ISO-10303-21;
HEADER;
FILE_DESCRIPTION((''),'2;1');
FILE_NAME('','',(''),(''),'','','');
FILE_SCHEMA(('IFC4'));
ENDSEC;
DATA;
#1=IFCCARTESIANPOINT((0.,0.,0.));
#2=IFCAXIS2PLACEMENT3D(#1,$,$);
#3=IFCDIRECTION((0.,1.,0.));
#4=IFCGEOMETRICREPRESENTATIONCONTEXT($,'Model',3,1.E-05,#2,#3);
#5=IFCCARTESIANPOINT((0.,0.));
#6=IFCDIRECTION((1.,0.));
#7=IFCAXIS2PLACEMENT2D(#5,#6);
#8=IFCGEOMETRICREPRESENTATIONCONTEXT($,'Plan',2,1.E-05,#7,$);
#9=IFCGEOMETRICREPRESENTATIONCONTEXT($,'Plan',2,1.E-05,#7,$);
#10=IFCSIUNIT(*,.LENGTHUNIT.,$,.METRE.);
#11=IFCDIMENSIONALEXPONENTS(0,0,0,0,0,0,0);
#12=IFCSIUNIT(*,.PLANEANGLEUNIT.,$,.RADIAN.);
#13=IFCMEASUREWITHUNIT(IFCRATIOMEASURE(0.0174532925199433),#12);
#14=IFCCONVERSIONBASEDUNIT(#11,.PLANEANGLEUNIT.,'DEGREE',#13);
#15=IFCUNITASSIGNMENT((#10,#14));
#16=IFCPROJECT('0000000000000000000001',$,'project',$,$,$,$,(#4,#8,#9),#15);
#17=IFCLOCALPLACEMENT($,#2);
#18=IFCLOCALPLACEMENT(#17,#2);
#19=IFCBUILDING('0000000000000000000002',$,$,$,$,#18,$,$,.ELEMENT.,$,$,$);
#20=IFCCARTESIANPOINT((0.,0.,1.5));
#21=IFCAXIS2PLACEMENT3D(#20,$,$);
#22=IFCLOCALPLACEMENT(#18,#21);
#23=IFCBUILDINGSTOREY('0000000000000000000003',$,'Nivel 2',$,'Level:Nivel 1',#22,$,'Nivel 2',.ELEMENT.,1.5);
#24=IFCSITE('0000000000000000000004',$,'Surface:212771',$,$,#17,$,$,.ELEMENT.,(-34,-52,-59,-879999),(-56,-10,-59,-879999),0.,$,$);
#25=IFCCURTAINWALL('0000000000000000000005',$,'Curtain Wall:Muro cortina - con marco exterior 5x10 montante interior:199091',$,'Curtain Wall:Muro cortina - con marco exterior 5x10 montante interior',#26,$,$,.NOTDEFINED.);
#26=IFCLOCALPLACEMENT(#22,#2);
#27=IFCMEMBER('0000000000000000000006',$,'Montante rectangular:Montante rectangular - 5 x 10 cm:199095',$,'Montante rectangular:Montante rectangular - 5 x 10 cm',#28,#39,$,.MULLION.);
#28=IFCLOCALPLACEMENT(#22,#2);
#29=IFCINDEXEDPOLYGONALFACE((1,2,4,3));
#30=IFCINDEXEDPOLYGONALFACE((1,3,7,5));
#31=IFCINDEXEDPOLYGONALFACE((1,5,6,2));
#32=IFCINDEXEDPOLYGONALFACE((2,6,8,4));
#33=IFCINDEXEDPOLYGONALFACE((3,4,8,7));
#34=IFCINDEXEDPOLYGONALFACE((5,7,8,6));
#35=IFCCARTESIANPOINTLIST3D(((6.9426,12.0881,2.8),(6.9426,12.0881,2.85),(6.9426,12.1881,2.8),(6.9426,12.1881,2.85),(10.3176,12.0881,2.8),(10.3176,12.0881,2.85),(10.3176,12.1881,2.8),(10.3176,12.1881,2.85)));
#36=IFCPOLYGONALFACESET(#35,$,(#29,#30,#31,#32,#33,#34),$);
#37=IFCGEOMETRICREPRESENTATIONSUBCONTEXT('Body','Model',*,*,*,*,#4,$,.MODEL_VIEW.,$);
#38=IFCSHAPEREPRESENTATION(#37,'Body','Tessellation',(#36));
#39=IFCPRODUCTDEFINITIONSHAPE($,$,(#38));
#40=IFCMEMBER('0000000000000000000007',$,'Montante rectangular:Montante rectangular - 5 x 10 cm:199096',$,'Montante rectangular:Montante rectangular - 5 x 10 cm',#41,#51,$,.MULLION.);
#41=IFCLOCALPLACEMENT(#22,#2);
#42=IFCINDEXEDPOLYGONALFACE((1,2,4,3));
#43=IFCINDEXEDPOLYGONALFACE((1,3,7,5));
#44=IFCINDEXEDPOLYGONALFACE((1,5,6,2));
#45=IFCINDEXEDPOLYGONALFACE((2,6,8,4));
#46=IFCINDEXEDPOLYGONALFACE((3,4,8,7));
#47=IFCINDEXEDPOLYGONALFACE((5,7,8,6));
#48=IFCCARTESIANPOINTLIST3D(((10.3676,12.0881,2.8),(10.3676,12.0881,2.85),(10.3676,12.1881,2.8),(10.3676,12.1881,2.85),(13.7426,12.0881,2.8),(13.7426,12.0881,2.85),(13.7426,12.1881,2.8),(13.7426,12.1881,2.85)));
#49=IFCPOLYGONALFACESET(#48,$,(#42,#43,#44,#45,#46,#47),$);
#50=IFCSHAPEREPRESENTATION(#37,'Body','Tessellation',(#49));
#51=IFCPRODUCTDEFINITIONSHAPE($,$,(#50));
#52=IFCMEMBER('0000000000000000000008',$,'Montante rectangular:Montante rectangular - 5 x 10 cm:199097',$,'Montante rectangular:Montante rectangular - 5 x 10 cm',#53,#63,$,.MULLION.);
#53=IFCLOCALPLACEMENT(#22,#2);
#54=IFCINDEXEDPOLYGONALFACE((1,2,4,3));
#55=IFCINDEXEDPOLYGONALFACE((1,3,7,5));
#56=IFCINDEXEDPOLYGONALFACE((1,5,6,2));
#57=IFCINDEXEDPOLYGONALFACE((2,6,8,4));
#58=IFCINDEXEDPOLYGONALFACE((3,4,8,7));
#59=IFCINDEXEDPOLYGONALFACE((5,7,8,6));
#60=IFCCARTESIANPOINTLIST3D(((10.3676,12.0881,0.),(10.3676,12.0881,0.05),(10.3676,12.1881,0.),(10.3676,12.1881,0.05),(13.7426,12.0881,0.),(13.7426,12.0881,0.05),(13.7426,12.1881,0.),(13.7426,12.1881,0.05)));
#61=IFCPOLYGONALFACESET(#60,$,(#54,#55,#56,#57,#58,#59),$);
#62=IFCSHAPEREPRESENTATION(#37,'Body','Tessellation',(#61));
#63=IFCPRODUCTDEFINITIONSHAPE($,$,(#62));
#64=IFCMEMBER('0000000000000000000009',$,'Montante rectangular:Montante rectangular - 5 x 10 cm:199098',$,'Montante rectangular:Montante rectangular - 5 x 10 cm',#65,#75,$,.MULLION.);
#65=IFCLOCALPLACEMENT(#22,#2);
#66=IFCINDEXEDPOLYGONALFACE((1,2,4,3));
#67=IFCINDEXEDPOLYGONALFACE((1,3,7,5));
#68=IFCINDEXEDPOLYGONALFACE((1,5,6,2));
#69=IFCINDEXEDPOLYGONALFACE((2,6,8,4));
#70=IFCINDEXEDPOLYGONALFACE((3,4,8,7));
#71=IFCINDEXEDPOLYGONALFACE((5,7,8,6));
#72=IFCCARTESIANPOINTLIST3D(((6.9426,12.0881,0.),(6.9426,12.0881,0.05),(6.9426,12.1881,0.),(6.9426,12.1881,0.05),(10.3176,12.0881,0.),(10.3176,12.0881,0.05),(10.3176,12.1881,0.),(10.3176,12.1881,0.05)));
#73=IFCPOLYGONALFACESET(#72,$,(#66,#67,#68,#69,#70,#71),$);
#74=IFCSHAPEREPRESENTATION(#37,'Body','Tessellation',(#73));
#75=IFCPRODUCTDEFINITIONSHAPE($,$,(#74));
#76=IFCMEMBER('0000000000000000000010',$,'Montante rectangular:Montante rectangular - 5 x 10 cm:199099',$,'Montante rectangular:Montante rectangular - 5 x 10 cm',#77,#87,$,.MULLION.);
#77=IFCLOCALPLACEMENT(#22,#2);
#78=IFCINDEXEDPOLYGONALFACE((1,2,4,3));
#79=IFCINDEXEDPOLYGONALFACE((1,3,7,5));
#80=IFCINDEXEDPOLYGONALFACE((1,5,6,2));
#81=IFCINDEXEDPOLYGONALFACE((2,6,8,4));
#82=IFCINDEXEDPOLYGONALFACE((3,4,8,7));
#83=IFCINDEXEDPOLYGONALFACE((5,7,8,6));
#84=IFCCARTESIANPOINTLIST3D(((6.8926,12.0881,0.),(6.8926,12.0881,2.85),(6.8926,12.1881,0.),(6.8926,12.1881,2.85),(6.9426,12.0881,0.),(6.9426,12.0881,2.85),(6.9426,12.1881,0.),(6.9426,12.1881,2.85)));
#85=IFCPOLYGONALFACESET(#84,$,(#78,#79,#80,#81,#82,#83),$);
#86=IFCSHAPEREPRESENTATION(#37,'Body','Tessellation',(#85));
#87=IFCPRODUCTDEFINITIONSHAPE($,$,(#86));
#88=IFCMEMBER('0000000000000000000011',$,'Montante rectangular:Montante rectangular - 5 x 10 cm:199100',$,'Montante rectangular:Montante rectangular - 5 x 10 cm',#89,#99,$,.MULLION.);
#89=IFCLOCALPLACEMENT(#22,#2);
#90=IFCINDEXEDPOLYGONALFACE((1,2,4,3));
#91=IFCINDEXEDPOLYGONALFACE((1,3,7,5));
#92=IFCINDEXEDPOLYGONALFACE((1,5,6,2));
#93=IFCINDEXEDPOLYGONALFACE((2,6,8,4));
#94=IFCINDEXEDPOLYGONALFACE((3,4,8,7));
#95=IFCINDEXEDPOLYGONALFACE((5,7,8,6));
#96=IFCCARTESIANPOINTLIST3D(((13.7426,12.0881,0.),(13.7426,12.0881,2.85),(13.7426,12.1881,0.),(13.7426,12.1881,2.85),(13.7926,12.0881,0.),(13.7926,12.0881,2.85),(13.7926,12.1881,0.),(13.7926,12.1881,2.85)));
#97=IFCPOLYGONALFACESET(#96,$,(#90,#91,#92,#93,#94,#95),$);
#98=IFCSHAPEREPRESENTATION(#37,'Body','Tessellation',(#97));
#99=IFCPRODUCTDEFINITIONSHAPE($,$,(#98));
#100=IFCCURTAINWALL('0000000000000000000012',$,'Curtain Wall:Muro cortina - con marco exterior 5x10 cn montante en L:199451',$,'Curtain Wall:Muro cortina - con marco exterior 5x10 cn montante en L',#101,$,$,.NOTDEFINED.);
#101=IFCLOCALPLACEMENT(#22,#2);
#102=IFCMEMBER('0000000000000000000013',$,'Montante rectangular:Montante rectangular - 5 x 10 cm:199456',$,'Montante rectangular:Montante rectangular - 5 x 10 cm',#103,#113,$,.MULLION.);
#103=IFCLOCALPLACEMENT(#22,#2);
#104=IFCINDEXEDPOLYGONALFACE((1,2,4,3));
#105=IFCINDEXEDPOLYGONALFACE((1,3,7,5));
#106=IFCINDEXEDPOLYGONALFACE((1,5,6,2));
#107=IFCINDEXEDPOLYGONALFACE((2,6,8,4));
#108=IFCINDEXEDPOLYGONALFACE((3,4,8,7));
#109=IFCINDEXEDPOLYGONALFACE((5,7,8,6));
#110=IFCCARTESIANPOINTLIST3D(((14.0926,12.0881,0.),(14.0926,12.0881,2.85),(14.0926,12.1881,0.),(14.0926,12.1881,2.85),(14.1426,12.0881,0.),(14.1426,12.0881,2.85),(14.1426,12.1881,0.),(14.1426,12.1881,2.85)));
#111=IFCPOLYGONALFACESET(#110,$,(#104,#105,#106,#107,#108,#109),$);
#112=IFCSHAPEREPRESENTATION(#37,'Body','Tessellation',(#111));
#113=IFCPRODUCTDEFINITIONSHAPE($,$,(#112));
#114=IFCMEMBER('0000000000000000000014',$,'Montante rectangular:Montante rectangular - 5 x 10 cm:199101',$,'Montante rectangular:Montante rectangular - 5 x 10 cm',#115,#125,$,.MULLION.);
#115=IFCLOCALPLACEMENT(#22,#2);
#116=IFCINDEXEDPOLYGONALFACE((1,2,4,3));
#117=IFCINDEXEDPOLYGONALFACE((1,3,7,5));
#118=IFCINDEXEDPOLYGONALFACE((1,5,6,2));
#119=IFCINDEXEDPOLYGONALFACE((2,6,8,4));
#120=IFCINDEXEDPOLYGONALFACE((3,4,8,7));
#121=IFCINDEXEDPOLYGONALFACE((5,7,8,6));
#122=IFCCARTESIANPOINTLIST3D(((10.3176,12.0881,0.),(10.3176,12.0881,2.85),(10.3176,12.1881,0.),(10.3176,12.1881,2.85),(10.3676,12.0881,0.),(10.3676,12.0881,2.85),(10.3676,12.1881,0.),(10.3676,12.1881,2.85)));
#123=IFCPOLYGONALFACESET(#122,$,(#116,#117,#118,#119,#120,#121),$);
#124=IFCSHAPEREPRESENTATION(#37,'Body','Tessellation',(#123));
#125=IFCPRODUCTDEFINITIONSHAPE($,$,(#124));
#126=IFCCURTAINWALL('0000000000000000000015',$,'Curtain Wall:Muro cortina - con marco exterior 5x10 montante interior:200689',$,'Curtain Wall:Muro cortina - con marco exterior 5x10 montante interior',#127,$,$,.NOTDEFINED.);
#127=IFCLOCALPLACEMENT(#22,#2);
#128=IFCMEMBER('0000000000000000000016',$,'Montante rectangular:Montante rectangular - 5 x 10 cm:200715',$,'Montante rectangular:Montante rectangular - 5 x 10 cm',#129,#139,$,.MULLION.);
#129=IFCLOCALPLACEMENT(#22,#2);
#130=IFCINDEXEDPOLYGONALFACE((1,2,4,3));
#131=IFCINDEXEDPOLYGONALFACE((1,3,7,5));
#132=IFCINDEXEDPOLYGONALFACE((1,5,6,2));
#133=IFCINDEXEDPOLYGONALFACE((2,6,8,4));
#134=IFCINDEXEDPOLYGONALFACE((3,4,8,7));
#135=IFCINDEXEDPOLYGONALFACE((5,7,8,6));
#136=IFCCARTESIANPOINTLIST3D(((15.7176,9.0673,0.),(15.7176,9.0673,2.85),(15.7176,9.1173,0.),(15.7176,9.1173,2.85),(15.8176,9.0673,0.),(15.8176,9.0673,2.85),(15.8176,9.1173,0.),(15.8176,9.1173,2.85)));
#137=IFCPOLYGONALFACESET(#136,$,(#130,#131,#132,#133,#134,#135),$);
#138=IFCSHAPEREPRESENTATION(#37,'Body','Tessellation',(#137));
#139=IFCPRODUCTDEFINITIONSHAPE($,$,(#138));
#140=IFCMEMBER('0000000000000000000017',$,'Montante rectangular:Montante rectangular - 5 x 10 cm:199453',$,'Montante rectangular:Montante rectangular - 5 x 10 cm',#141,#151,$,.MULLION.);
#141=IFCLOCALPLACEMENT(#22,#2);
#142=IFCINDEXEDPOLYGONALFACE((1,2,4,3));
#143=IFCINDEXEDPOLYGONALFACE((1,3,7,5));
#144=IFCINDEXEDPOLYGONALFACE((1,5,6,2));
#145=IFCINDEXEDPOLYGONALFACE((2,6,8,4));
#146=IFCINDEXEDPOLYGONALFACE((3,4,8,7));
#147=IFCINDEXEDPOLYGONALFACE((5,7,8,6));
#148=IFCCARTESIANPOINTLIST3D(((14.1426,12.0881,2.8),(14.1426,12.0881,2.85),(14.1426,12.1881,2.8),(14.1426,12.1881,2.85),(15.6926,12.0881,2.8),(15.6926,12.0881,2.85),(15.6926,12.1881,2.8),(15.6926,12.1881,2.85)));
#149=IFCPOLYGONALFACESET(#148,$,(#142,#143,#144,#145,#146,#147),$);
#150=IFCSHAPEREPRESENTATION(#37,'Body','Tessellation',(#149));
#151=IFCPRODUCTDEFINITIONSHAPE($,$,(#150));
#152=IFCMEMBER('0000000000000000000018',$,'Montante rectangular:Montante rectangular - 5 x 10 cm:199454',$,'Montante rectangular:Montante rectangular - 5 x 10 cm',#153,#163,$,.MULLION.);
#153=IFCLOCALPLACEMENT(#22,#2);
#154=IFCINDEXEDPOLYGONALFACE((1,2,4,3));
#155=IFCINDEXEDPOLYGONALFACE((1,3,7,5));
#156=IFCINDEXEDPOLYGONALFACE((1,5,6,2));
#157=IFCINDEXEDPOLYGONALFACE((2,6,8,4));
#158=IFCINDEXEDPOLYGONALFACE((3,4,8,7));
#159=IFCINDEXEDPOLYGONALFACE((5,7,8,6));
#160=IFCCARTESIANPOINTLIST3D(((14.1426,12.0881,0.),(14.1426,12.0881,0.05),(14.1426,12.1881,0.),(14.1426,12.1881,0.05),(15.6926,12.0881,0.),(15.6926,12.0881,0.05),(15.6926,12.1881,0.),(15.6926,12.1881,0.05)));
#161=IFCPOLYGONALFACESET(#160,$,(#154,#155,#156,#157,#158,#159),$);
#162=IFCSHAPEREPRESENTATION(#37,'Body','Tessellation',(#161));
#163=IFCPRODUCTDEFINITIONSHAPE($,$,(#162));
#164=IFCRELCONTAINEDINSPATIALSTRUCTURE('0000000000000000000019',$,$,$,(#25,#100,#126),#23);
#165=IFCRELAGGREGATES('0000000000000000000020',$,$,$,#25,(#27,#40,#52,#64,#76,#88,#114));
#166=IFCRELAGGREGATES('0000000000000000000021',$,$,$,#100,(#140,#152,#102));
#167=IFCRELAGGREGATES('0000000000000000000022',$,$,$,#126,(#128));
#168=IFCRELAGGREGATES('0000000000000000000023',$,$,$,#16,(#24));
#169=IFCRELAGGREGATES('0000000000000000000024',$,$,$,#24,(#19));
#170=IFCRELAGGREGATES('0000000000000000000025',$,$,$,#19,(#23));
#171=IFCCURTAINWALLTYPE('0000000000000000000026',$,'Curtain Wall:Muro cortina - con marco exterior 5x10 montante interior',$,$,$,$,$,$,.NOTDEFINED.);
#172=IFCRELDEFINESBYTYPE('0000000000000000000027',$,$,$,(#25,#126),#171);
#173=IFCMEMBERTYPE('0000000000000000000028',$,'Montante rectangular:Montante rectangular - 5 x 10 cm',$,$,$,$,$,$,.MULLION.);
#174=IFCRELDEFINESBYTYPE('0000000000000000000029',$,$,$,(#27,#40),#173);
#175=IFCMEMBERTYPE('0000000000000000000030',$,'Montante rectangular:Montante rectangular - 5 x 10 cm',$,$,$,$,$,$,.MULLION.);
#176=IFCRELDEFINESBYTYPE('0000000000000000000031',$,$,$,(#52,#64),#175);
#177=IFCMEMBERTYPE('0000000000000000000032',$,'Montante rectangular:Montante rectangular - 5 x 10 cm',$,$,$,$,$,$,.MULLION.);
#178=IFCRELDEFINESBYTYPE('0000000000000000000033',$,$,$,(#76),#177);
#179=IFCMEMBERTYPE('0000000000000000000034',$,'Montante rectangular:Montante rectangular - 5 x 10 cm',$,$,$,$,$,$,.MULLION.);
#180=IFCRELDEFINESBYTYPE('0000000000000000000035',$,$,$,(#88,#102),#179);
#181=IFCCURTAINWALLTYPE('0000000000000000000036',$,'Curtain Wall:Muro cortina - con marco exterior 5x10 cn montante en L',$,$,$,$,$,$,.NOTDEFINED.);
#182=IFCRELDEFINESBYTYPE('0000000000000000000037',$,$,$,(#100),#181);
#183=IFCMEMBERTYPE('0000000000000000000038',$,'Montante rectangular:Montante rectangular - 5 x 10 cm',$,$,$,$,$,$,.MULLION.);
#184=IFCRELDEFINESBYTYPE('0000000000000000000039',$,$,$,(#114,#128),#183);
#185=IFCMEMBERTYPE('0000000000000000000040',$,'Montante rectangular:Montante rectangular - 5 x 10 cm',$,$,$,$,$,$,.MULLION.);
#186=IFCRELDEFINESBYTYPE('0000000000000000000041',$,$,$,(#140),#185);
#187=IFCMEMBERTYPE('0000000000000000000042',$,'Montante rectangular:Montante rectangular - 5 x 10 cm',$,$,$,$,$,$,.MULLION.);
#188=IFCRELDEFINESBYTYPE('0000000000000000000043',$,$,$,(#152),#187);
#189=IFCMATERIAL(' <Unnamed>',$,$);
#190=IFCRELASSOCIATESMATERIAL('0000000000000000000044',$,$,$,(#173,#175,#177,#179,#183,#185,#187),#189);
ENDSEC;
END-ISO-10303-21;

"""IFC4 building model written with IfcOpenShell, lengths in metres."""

from ifc_helpers import new_model, entity, si_unit, converted_unit, direction, frame, origin, origin_2d_with_axis, place, context, subcontext, project, spatial, indexed_curve, outline, extrude, source, transform, mapped, material, type_object, type_shapes, element, aggregate, save


model = new_model("IFC4")

# Units and contexts
model_context = context("Model", 3, precision=1e-05, world=origin(), true_north=direction((0.0, 1.0, 0.0)))
plan_context_1 = context("Plan", 2, precision=1e-05, world=origin_2d_with_axis())
plan_context_2 = context("Plan", 2, precision=1e-05, world=origin_2d_with_axis())
body_context = subcontext(model_context, "Body", "Model", "MODEL_VIEW")
ifc_project = project(units=[si_unit("LENGTHUNIT", "METRE"), converted_unit("PLANEANGLEUNIT", "DEGREE", entity("IfcRatioMeasure", 0.0174532925199433), si_unit("PLANEANGLEUNIT", "RADIAN"), dimensions=[0, 0, 0, 0, 0, 0, 0])], contexts=[model_context, plan_context_1, plan_context_2])

# Site, building, storey
site_placement = place(None, origin())
site = spatial("IfcSite", under=ifc_project, at=site_placement, Name="Surface:212771", CompositionType="ELEMENT", RefLatitude=(-34, -52, -59, -879999), RefLongitude=(-56, -10, -59, -879999), RefElevation=0.0)
building_placement = place(site_placement, origin())
building = spatial("IfcBuilding", under=site, at=building_placement, CompositionType="ELEMENT")
storey_placement = place(building_placement, frame((0.0, 0.0, 1.5)))
storey = spatial("IfcBuildingStorey", under=building, at=storey_placement, Name="Nivel 2", ObjectType="Level:Nivel 1", LongName="Nivel 2", CompositionType="ELEMENT", Elevation=1.5)

# Curtain wall, members
curtain_wall_type_1 = type_object("IfcCurtainWallType", Name="Curtain Wall:Muro cortina - con marco exterior 5x10 montante interior", PredefinedType="NOTDEFINED")
curtain_wall_1_placement = place(storey_placement, frame((0.0, 0.0, -1.5)))
curtain_wall_1 = element("IfcCurtainWall", 1, at=curtain_wall_1_placement, inside=storey, type_object=curtain_wall_type_1, Name="Curtain Wall:Muro cortina - con marco exterior 5x10 montante interior:199091", ObjectType="Curtain Wall:Muro cortina - con marco exterior 5x10 montante interior", PredefinedType="NOTDEFINED")
ifc_material_1 = material(Name=" <Unnamed>")
member_type_1 = type_object("IfcMemberType", Name="Montante rectangular:Montante rectangular - 5 x 10 cm", PredefinedType="MULLION", material=ifc_material_1)
shared_shape_1 = source(origin(), body_context, "Body", "SweptSolid", [
    extrude(outline(indexed_curve([(-0.05, -0.025), (0.05, -0.025), (0.05, 0.025), (-0.05, 0.025), (-0.05, -0.025)], self_intersect=False)), frame((-0.025, 0.0, -3.375), z_axis=(0.0, 0.0, 1.0), x_axis=(0.0, -1.0, 0.0)), (0.0, 0.0, 1.0), 3.375),
])
type_shapes(member_type_1, [shared_shape_1])
placement = place(building_placement, frame((0.0, 0.0, 0.75)))
member_1_placement = place(placement, frame((6.9426, 12.1381, 3.6), z_axis=(-1.0, 0.0, 0.0), x_axis=(0.0, 0.0, 1.0)))
member_1 = element("IfcMember", 2, at=member_1_placement, type_object=member_type_1, Name="Montante rectangular:Montante rectangular - 5 x 10 cm:199095", ObjectType="Montante rectangular:Montante rectangular - 5 x 10 cm", PredefinedType="MULLION", context=body_context, shape_type="MappedRepresentation", body=[
    mapped(shared_shape_1, transform((0.0, 0.0, 0.0), scale=1.0)),
])
member_2_placement = place(placement, frame((10.3676, 12.1381, 3.6), z_axis=(-1.0, 0.0, 0.0), x_axis=(0.0, 0.0, 1.0)))
member_2 = element("IfcMember", 3, at=member_2_placement, type_object=member_type_1, Name="Montante rectangular:Montante rectangular - 5 x 10 cm:199096", ObjectType="Montante rectangular:Montante rectangular - 5 x 10 cm", PredefinedType="MULLION", context=body_context, shape_type="MappedRepresentation", body=[
    mapped(shared_shape_1, transform((0.0, 0.0, 0.0), scale=1.0)),
])
member_type_2 = type_object("IfcMemberType", Name="Montante rectangular:Montante rectangular - 5 x 10 cm", PredefinedType="MULLION", material=ifc_material_1)
shared_shape_2 = source(origin(), body_context, "Body", "SweptSolid", [
    extrude(outline(indexed_curve([(-0.05, -0.025), (0.05, -0.025), (0.05, 0.025), (-0.05, 0.025), (-0.05, -0.025)], self_intersect=False)), frame((-0.025, 0.0, -3.375), z_axis=(0.0, 0.0, 1.0), x_axis=(0.0, -1.0, 0.0)), (0.0, 0.0, 1.0), 3.375),
])
type_shapes(member_type_2, [shared_shape_2])
member_3_placement = place(placement, frame((13.7426, 12.1381, 0.75), z_axis=(1.0, 0.0, 0.0), x_axis=(0.0, 0.0, -1.0)))
member_3 = element("IfcMember", 4, at=member_3_placement, type_object=member_type_2, Name="Montante rectangular:Montante rectangular - 5 x 10 cm:199097", ObjectType="Montante rectangular:Montante rectangular - 5 x 10 cm", PredefinedType="MULLION", context=body_context, shape_type="MappedRepresentation", body=[
    mapped(shared_shape_2, transform((0.0, 0.0, 0.0), scale=1.0)),
])
member_4_placement = place(placement, frame((10.3176, 12.1381, 0.75), z_axis=(1.0, 0.0, 0.0), x_axis=(0.0, 0.0, -1.0)))
member_4 = element("IfcMember", 5, at=member_4_placement, type_object=member_type_2, Name="Montante rectangular:Montante rectangular - 5 x 10 cm:199098", ObjectType="Montante rectangular:Montante rectangular - 5 x 10 cm", PredefinedType="MULLION", context=body_context, shape_type="MappedRepresentation", body=[
    mapped(shared_shape_2, transform((0.0, 0.0, 0.0), scale=1.0)),
])
member_type_3 = type_object("IfcMemberType", Name="Montante rectangular:Montante rectangular - 5 x 10 cm", PredefinedType="MULLION", material=ifc_material_1)
shared_shape_3 = source(origin(), body_context, "Body", "SweptSolid", [
    extrude(outline(indexed_curve([(-0.05, -0.025), (0.05, -0.025), (0.05, 0.025), (-0.05, 0.025), (-0.05, -0.025)], self_intersect=False)), frame((-0.025, 0.0, -2.85), z_axis=(0.0, 0.0, 1.0), x_axis=(0.0, -1.0, 0.0)), (0.0, 0.0, 1.0), 2.85),
])
type_shapes(member_type_3, [shared_shape_3])
member_5_placement = place(placement, frame((6.8926, 12.1381, 0.75), z_axis=(0.0, 0.0, -1.0), x_axis=(-1.0, 0.0, 0.0)))
member_5 = element("IfcMember", 6, at=member_5_placement, type_object=member_type_3, Name="Montante rectangular:Montante rectangular - 5 x 10 cm:199099", ObjectType="Montante rectangular:Montante rectangular - 5 x 10 cm", PredefinedType="MULLION", context=body_context, shape_type="MappedRepresentation", body=[
    mapped(shared_shape_3, transform((0.0, 0.0, 0.0), scale=1.0)),
])
member_type_4 = type_object("IfcMemberType", Name="Montante rectangular:Montante rectangular - 5 x 10 cm", PredefinedType="MULLION", material=ifc_material_1)
shared_shape_4 = source(origin(), body_context, "Body", "SweptSolid", [
    extrude(outline(indexed_curve([(-0.05, -0.025), (0.05, -0.025), (0.05, 0.025), (-0.05, 0.025), (-0.05, -0.025)], self_intersect=False)), frame((-0.025, 0.0, -2.85), z_axis=(0.0, 0.0, 1.0), x_axis=(0.0, -1.0, 0.0)), (0.0, 0.0, 1.0), 2.85),
])
type_shapes(member_type_4, [shared_shape_4])
member_6_placement = place(placement, frame((13.7926, 12.1381, 3.6)))
member_6 = element("IfcMember", 7, at=member_6_placement, type_object=member_type_4, Name="Montante rectangular:Montante rectangular - 5 x 10 cm:199100", ObjectType="Montante rectangular:Montante rectangular - 5 x 10 cm", PredefinedType="MULLION", context=body_context, shape_type="MappedRepresentation", body=[
    mapped(shared_shape_4, transform((0.0, 0.0, 0.0), scale=1.0)),
])

# Curtain wall, member
curtain_wall_type_2 = type_object("IfcCurtainWallType", Name="Curtain Wall:Muro cortina - con marco exterior 5x10 cn montante en L", PredefinedType="NOTDEFINED")
curtain_wall_2_placement = place(storey_placement, frame((0.0, 0.0, -1.5)))
curtain_wall_2 = element("IfcCurtainWall", 8, at=curtain_wall_2_placement, inside=storey, type_object=curtain_wall_type_2, Name="Curtain Wall:Muro cortina - con marco exterior 5x10 cn montante en L:199451", ObjectType="Curtain Wall:Muro cortina - con marco exterior 5x10 cn montante en L", PredefinedType="NOTDEFINED")
member_7_placement = place(storey_placement, frame((14.0926, 12.1381, 2.85), z_axis=(0.0, 0.0, 1.0), x_axis=(-1.0, 0.0, 0.0)))
member_7 = element("IfcMember", 9, at=member_7_placement, type_object=member_type_4, Name="Montante rectangular:Montante rectangular - 5 x 10 cm:199456", ObjectType="Montante rectangular:Montante rectangular - 5 x 10 cm", PredefinedType="MULLION", context=body_context, shape_type="MappedRepresentation", body=[
    mapped(shared_shape_4, transform((0.0, 0.0, 0.0), scale=1.0)),
])

# Member
member_type_5 = type_object("IfcMemberType", Name="Montante rectangular:Montante rectangular - 5 x 10 cm", PredefinedType="MULLION", material=ifc_material_1)
shared_shape_5 = source(origin(), body_context, "Body", "SweptSolid", [
    extrude(outline(indexed_curve([(-0.05, -0.025), (0.05, -0.025), (0.05, 0.025), (-0.05, 0.025), (-0.05, -0.025)], self_intersect=False)), frame((0.0, 0.0, -2.85), z_axis=(0.0, 0.0, 1.0), x_axis=(0.0, -1.0, 0.0)), (0.0, 0.0, 1.0), 2.85),
])
type_shapes(member_type_5, [shared_shape_5])
member_8_placement = place(placement, frame((10.3426, 12.1381, 0.75), z_axis=(0.0, 0.0, -1.0), x_axis=(-1.0, 0.0, 0.0)))
member_8 = element("IfcMember", 10, at=member_8_placement, type_object=member_type_5, Name="Montante rectangular:Montante rectangular - 5 x 10 cm:199101", ObjectType="Montante rectangular:Montante rectangular - 5 x 10 cm", PredefinedType="MULLION", context=body_context, shape_type="MappedRepresentation", body=[
    mapped(shared_shape_5, transform((0.0, 0.0, 0.0), scale=1.0)),
])

# Curtain wall, member
curtain_wall_3_placement = place(storey_placement, frame((0.0, 0.0, -1.5)))
curtain_wall_3 = element("IfcCurtainWall", 11, at=curtain_wall_3_placement, inside=storey, type_object=curtain_wall_type_1, Name="Curtain Wall:Muro cortina - con marco exterior 5x10 montante interior:200689", ObjectType="Curtain Wall:Muro cortina - con marco exterior 5x10 montante interior", PredefinedType="NOTDEFINED")
member_9_placement = place(storey_placement, frame((15.7676, 9.0923, 0.0), z_axis=(0.0, 0.0, -1.0), x_axis=(0.0, 1.0, 0.0)))
member_9 = element("IfcMember", 12, at=member_9_placement, type_object=member_type_5, Name="Montante rectangular:Montante rectangular - 5 x 10 cm:200715", ObjectType="Montante rectangular:Montante rectangular - 5 x 10 cm", PredefinedType="MULLION", context=body_context, shape_type="MappedRepresentation", body=[
    mapped(shared_shape_5, transform((0.0, 0.0, 0.0), scale=1.0)),
])

# Members
member_type_6 = type_object("IfcMemberType", Name="Montante rectangular:Montante rectangular - 5 x 10 cm", PredefinedType="MULLION", material=ifc_material_1)
shared_shape_6 = source(origin(), body_context, "Body", "SweptSolid", [
    extrude(outline(indexed_curve([(-0.05, -0.025), (0.05, -0.025), (0.05, 0.025), (-0.05, 0.025), (-0.05, -0.025)], self_intersect=False)), frame((-0.025, 0.0, -1.55), z_axis=(0.0, 0.0, 1.0), x_axis=(0.0, -1.0, 0.0)), (0.0, 0.0, 1.0), 1.55),
])
type_shapes(member_type_6, [shared_shape_6])
member_10_placement = place(storey_placement, frame((15.6926, 12.1381, 2.85), z_axis=(1.0, 0.0, 0.0), x_axis=(0.0, 0.0, 1.0)))
member_10 = element("IfcMember", 13, at=member_10_placement, type_object=member_type_6, Name="Montante rectangular:Montante rectangular - 5 x 10 cm:199453", ObjectType="Montante rectangular:Montante rectangular - 5 x 10 cm", PredefinedType="MULLION", context=body_context, shape_type="MappedRepresentation", body=[
    mapped(shared_shape_6, transform((0.0, 0.0, 0.0), scale=1.0)),
])
member_type_7 = type_object("IfcMemberType", Name="Montante rectangular:Montante rectangular - 5 x 10 cm", PredefinedType="MULLION", material=ifc_material_1)
shared_shape_7 = source(origin(), body_context, "Body", "SweptSolid", [
    extrude(outline(indexed_curve([(-0.05, -0.025), (0.05, -0.025), (0.05, 0.025), (-0.05, 0.025), (-0.05, -0.025)], self_intersect=False)), frame((-0.025, 0.0, -1.55), z_axis=(0.0, 0.0, 1.0), x_axis=(0.0, -1.0, 0.0)), (0.0, 0.0, 1.0), 1.55),
])
type_shapes(member_type_7, [shared_shape_7])
member_11_placement = place(storey_placement, frame((14.1426, 12.1381, 0.0), z_axis=(-1.0, 0.0, 0.0), x_axis=(0.0, 0.0, -1.0)))
member_11 = element("IfcMember", 14, at=member_11_placement, type_object=member_type_7, Name="Montante rectangular:Montante rectangular - 5 x 10 cm:199454", ObjectType="Montante rectangular:Montante rectangular - 5 x 10 cm", PredefinedType="MULLION", context=body_context, shape_type="MappedRepresentation", body=[
    mapped(shared_shape_7, transform((0.0, 0.0, 0.0), scale=1.0)),
])

aggregate(curtain_wall_1, [member_1, member_2, member_3, member_4, member_5, member_6, member_8])
aggregate(curtain_wall_2, [member_10, member_11, member_7])
aggregate(curtain_wall_3, [member_9])

save(model, "model.ifc")
